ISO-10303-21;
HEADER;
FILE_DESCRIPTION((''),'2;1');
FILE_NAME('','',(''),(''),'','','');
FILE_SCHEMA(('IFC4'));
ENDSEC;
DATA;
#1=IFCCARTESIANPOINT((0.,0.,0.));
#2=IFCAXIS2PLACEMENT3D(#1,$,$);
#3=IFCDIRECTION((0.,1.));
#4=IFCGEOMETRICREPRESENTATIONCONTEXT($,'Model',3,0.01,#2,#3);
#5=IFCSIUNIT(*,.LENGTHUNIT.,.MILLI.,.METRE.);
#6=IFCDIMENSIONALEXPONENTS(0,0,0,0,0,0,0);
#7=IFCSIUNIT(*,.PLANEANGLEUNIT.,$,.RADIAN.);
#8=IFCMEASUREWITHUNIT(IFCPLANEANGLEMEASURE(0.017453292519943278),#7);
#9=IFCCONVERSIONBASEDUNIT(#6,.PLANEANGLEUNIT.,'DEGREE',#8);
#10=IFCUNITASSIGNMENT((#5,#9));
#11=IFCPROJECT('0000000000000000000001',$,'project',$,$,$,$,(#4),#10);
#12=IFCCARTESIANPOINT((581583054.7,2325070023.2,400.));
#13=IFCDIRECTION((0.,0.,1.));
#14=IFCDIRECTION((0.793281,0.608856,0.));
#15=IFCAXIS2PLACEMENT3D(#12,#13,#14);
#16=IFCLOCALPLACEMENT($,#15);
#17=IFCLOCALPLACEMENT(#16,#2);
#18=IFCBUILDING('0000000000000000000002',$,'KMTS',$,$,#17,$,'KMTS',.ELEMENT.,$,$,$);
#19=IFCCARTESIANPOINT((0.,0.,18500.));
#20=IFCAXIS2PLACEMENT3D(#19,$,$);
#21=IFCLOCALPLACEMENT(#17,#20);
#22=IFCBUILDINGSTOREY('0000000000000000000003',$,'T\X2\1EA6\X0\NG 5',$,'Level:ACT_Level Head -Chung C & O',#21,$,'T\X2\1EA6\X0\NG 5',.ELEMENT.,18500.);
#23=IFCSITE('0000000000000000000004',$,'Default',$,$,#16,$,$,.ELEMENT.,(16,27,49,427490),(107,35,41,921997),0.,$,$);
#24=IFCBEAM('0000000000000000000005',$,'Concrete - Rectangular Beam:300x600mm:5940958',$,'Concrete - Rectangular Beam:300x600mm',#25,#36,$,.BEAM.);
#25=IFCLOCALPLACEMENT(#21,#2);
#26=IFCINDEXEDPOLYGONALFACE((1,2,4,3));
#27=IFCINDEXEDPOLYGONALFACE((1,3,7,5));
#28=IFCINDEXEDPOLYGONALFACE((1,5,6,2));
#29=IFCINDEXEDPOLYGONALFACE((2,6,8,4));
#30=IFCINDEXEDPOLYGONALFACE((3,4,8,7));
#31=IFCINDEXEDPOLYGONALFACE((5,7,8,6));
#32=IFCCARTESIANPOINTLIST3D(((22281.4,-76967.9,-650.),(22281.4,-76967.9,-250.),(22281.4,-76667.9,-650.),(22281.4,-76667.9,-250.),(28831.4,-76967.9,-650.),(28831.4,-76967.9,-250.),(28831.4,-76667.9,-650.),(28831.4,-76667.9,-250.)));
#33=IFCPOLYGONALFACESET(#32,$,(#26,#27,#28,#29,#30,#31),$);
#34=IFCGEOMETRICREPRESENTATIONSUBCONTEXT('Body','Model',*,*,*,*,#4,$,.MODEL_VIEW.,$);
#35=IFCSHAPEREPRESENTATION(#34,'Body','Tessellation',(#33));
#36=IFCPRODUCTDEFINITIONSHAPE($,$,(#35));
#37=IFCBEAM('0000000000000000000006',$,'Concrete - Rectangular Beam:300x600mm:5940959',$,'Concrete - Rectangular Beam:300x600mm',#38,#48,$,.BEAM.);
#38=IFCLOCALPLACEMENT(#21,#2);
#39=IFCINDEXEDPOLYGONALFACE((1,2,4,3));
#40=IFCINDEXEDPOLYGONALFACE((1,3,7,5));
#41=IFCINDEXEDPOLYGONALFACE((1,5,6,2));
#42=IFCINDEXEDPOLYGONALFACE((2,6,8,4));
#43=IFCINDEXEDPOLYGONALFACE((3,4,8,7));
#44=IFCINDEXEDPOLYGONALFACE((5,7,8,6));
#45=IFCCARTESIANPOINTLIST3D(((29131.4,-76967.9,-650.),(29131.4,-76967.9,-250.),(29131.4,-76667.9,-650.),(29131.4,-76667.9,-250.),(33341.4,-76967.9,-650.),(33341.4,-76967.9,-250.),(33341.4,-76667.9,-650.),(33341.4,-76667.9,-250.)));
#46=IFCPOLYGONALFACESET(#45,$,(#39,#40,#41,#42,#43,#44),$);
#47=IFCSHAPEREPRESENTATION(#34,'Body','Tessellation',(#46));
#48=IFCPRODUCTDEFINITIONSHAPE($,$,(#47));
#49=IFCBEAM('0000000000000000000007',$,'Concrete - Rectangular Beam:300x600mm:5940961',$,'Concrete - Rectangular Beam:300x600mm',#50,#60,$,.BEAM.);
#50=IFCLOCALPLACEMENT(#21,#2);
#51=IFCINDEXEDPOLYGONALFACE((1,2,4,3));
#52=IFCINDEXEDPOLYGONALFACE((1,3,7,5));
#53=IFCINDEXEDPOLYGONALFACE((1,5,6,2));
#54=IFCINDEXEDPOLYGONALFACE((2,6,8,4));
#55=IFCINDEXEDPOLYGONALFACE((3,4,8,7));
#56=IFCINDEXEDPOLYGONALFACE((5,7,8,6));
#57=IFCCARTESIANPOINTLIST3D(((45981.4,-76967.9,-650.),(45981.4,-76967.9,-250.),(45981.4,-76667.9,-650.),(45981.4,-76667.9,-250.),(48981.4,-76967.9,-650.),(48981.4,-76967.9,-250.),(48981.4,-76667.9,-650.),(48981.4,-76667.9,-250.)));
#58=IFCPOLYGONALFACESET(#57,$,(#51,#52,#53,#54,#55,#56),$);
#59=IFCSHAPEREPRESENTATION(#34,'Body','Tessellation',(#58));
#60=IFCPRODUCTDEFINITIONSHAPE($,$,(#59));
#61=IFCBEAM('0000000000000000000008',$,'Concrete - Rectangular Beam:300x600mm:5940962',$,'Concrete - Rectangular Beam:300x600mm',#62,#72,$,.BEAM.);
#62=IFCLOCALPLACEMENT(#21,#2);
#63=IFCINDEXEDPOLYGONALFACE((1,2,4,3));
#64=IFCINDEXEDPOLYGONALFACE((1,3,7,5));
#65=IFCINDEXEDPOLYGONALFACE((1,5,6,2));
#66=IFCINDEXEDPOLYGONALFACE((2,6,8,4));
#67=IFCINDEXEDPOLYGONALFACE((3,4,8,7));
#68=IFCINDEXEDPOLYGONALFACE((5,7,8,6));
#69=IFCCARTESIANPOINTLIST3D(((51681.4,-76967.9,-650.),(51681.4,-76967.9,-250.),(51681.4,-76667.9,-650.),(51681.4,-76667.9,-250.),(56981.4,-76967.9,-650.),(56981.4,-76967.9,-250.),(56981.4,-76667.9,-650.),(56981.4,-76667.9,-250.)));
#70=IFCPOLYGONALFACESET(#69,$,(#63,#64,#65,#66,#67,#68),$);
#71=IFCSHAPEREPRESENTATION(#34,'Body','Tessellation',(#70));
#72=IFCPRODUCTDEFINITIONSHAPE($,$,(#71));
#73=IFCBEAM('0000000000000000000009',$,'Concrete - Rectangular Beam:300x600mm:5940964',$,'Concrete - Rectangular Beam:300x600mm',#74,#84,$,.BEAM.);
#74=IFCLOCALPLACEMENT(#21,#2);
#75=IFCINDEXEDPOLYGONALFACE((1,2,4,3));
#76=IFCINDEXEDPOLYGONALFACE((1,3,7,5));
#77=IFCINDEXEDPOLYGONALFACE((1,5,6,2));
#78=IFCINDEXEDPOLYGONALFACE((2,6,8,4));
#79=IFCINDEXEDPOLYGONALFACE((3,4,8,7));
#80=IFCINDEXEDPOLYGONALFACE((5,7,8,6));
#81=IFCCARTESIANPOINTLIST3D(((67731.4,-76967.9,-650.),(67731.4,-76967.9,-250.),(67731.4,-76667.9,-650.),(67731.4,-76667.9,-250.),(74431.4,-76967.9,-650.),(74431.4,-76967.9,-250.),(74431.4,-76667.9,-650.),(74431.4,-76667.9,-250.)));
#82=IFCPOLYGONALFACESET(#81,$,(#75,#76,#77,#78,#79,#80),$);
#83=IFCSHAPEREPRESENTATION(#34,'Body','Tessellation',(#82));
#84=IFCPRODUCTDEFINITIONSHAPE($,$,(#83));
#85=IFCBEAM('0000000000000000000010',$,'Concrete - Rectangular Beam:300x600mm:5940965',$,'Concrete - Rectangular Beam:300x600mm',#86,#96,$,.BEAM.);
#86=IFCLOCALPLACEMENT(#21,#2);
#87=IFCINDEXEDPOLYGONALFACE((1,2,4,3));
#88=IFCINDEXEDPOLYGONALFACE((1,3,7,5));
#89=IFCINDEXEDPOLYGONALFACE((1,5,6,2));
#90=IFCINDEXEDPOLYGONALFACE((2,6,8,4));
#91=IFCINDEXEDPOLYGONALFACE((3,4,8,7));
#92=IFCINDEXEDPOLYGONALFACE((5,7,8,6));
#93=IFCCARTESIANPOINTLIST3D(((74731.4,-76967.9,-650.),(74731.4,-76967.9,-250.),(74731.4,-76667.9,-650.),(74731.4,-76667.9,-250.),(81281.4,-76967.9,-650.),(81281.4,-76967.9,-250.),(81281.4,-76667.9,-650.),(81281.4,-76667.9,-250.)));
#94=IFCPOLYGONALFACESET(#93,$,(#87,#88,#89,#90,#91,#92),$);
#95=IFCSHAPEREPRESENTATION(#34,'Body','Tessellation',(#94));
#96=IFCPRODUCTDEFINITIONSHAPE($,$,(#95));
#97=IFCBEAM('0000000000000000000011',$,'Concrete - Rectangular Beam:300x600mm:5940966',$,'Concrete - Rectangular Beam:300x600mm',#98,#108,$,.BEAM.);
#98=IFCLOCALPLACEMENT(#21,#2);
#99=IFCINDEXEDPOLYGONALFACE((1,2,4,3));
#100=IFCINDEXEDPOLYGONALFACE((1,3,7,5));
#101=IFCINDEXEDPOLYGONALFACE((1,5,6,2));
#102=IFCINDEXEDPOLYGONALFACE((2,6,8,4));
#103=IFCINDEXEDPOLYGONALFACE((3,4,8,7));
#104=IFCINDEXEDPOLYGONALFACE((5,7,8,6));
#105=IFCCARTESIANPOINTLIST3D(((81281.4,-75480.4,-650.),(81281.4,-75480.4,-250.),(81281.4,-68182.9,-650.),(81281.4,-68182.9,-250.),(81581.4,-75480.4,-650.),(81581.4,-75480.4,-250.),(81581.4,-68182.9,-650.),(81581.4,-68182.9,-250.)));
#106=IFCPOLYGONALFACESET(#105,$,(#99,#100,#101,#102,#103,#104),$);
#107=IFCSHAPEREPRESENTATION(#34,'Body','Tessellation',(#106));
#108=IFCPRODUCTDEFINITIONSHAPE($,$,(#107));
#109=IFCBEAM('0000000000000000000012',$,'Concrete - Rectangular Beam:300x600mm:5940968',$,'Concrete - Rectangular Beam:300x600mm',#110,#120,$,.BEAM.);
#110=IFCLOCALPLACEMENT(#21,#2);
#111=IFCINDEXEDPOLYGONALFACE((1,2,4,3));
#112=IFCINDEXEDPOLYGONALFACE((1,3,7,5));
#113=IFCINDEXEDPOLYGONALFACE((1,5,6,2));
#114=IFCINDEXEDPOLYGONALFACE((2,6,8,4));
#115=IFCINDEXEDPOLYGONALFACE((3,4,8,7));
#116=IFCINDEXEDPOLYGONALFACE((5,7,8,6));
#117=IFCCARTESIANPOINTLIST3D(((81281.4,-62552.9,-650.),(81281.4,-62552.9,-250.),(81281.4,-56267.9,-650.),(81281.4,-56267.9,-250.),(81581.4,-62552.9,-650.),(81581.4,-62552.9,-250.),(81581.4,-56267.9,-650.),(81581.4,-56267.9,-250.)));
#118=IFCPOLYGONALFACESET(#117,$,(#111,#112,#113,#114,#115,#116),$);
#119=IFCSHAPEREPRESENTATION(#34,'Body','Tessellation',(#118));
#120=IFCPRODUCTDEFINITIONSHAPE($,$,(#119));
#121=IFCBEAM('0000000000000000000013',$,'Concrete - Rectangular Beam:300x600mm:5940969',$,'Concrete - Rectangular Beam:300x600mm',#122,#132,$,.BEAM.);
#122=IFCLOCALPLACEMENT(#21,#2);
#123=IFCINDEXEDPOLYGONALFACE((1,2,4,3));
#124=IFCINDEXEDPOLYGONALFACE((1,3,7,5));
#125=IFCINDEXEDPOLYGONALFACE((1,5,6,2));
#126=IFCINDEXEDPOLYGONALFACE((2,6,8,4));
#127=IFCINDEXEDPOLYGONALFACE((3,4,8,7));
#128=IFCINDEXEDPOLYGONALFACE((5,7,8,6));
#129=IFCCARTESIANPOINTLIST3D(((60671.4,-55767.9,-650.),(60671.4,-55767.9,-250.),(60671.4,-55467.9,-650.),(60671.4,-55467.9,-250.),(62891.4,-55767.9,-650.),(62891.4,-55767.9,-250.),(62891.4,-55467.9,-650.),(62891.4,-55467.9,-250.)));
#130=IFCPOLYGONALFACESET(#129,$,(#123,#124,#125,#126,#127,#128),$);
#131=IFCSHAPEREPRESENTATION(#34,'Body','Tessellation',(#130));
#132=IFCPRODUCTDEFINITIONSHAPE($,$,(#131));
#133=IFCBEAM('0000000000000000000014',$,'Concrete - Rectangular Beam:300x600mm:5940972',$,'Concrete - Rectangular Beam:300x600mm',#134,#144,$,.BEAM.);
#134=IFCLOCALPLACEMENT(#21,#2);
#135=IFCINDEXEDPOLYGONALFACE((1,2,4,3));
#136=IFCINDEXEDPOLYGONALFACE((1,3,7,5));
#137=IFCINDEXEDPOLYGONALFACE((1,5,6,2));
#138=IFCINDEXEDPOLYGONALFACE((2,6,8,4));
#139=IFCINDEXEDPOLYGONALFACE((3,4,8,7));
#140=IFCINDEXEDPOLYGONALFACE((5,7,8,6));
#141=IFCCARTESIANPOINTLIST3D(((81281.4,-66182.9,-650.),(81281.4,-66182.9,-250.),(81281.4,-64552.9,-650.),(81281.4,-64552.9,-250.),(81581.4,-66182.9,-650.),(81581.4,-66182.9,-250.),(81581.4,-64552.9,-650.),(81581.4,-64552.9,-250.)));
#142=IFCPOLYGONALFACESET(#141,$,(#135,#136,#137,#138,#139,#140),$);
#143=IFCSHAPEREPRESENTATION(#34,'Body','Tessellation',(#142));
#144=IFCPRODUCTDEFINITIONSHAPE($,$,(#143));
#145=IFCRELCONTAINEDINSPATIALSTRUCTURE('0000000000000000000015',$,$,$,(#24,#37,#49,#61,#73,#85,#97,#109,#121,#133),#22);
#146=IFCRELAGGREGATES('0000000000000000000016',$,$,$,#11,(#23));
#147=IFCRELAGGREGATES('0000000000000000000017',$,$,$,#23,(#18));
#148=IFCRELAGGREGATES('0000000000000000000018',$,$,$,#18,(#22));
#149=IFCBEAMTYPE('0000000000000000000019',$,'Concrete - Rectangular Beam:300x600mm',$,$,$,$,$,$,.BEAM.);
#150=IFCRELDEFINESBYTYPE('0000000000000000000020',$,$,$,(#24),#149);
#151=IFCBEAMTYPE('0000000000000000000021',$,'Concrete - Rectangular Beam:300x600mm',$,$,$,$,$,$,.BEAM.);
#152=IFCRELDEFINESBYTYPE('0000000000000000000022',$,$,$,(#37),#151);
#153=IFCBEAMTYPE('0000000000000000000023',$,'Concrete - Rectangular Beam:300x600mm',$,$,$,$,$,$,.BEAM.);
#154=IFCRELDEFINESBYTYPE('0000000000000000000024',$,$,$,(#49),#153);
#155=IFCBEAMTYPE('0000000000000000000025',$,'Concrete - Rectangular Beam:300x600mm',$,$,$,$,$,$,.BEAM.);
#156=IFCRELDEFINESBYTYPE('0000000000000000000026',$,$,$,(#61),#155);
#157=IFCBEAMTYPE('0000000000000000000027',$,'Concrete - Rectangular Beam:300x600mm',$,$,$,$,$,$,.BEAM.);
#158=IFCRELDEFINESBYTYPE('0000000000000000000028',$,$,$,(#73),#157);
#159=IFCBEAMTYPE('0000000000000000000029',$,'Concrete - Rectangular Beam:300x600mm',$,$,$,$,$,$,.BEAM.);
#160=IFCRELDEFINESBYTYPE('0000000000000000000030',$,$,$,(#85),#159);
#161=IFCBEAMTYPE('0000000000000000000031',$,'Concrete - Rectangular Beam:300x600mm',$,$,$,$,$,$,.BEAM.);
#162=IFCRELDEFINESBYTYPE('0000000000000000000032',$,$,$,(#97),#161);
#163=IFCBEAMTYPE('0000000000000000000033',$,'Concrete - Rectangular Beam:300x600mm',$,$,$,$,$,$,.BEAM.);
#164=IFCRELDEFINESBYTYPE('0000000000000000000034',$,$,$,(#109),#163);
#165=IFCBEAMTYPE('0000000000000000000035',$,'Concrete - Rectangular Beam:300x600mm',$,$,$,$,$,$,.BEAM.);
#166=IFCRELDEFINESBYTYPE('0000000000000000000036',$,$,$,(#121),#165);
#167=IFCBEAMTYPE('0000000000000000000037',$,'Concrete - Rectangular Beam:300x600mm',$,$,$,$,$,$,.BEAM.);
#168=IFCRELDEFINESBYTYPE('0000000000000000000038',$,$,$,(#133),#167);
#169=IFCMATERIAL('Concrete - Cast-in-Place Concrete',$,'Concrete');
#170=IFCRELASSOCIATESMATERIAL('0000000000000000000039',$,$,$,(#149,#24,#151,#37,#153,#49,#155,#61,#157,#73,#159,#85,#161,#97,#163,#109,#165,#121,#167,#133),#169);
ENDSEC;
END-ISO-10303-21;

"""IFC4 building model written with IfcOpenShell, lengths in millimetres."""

from ifc_helpers import new_model, entity, si_unit, converted_unit, direction, frame, origin, place, context, subcontext, project, spatial, indexed_curve, outline, extrude, source, transform, mapped, material, type_object, type_shapes, element, save


model = new_model("IFC4")

# Units and contexts
model_context = context("Model", 3, precision=0.01, world=origin(), true_north=direction((0.0, 1.0)))
body_context = subcontext(model_context, "Body", "Model", "MODEL_VIEW")
ifc_project = project(units=[si_unit("LENGTHUNIT", "METRE", prefix="MILLI"), converted_unit("PLANEANGLEUNIT", "DEGREE", entity("IfcPlaneAngleMeasure", 0.017453292519943278), si_unit("PLANEANGLEUNIT", "RADIAN"), dimensions=[0, 0, 0, 0, 0, 0, 0])], contexts=[model_context])

# Site, building, storey
site_placement = place(None, frame((581583054.7, 2325070023.2, 400.0), z_axis=(0.0, 0.0, 1.0), x_axis=(0.793281, 0.608856, 0.0)))
site = spatial("IfcSite", under=ifc_project, at=site_placement, Name="Default", CompositionType="ELEMENT", RefLatitude=(16, 27, 49, 427490), RefLongitude=(107, 35, 41, 921997), RefElevation=0.0)
building_placement = place(site_placement, origin())
building = spatial("IfcBuilding", under=site, at=building_placement, Name="KMTS", LongName="KMTS", CompositionType="ELEMENT")
storey_placement = place(building_placement, frame((0.0, 0.0, 18500.0)))
storey = spatial("IfcBuildingStorey", under=building, at=storey_placement, Name="TẦNG 5", ObjectType="Level:ACT_Level Head -Chung C & O", LongName="TẦNG 5", CompositionType="ELEMENT", Elevation=18500.0)

# Beams
ifc_material_1 = material(Name="Concrete - Cast-in-Place Concrete", Category="Concrete")
beam_type_1 = type_object("IfcBeamType", Name="Concrete - Rectangular Beam:300x600mm", PredefinedType="BEAM", material=ifc_material_1)
shared_shape_1 = source(origin(), body_context, "Body", "SweptSolid", [
    extrude(outline(indexed_curve([(-200.0, -150.0), (200.0, -150.0), (200.0, 150.0), (-200.0, 150.0), (-200.0, -150.0)], self_intersect=False)), frame((22281.4, -76817.9, 18050.0), z_axis=(1.0, 0.0, 0.0), x_axis=(0.0, 0.0, -1.0)), (0.0, 0.0, 1.0), 6550.0),
])
type_shapes(beam_type_1, [shared_shape_1])
beam_1_placement = place(storey_placement, frame((0.0, 0.0, -18500.0)))
element("IfcBeam", 1, at=beam_1_placement, inside=storey, type_object=beam_type_1, material=ifc_material_1, Name="Concrete - Rectangular Beam:300x600mm:5940958", ObjectType="Concrete - Rectangular Beam:300x600mm", PredefinedType="BEAM", context=body_context, shape_type="MappedRepresentation", body=[
    mapped(shared_shape_1, transform((0.0, 0.0, 0.0), scale=1.0)),
])
beam_type_2 = type_object("IfcBeamType", Name="Concrete - Rectangular Beam:300x600mm", PredefinedType="BEAM", material=ifc_material_1)
shared_shape_2 = source(origin(), body_context, "Body", "SweptSolid", [
    extrude(outline(indexed_curve([(-200.0, -150.0), (200.0, -150.0), (200.0, 150.0), (-200.0, 150.0), (-200.0, -150.0)], self_intersect=False)), frame((29131.4, -76817.9, 18050.0), z_axis=(1.0, 0.0, 0.0), x_axis=(0.0, 0.0, -1.0)), (0.0, 0.0, 1.0), 4210.0),
])
type_shapes(beam_type_2, [shared_shape_2])
beam_2_placement = place(storey_placement, frame((0.0, 0.0, -18500.0)))
element("IfcBeam", 2, at=beam_2_placement, inside=storey, type_object=beam_type_2, material=ifc_material_1, Name="Concrete - Rectangular Beam:300x600mm:5940959", ObjectType="Concrete - Rectangular Beam:300x600mm", PredefinedType="BEAM", context=body_context, shape_type="MappedRepresentation", body=[
    mapped(shared_shape_2, transform((0.0, 0.0, 0.0), scale=1.0)),
])
beam_type_3 = type_object("IfcBeamType", Name="Concrete - Rectangular Beam:300x600mm", PredefinedType="BEAM", material=ifc_material_1)
shared_shape_3 = source(origin(), body_context, "Body", "SweptSolid", [
    extrude(outline(indexed_curve([(-200.0, -150.0), (200.0, -150.0), (200.0, 150.0), (-200.0, 150.0), (-200.0, -150.0)], self_intersect=False)), frame((45981.4, -76817.9, 18050.0), z_axis=(1.0, 0.0, 0.0), x_axis=(0.0, 0.0, -1.0)), (0.0, 0.0, 1.0), 3000.0),
])
type_shapes(beam_type_3, [shared_shape_3])
beam_3_placement = place(storey_placement, frame((0.0, 0.0, -18500.0)))
element("IfcBeam", 3, at=beam_3_placement, inside=storey, type_object=beam_type_3, material=ifc_material_1, Name="Concrete - Rectangular Beam:300x600mm:5940961", ObjectType="Concrete - Rectangular Beam:300x600mm", PredefinedType="BEAM", context=body_context, shape_type="MappedRepresentation", body=[
    mapped(shared_shape_3, transform((0.0, 0.0, 0.0), scale=1.0)),
])
beam_type_4 = type_object("IfcBeamType", Name="Concrete - Rectangular Beam:300x600mm", PredefinedType="BEAM", material=ifc_material_1)
shared_shape_4 = source(origin(), body_context, "Body", "SweptSolid", [
    extrude(outline(indexed_curve([(-200.0, -150.0), (200.0, -150.0), (200.0, 150.0), (-200.0, 150.0), (-200.0, -150.0)], self_intersect=False)), frame((51681.4, -76817.9, 18050.0), z_axis=(1.0, 0.0, 0.0), x_axis=(0.0, 0.0, -1.0)), (0.0, 0.0, 1.0), 5300.0),
])
type_shapes(beam_type_4, [shared_shape_4])
beam_4_placement = place(storey_placement, frame((0.0, 0.0, -18500.0)))
element("IfcBeam", 4, at=beam_4_placement, inside=storey, type_object=beam_type_4, material=ifc_material_1, Name="Concrete - Rectangular Beam:300x600mm:5940962", ObjectType="Concrete - Rectangular Beam:300x600mm", PredefinedType="BEAM", context=body_context, shape_type="MappedRepresentation", body=[
    mapped(shared_shape_4, transform((0.0, 0.0, 0.0), scale=1.0)),
])
beam_type_5 = type_object("IfcBeamType", Name="Concrete - Rectangular Beam:300x600mm", PredefinedType="BEAM", material=ifc_material_1)
shared_shape_5 = source(origin(), body_context, "Body", "SweptSolid", [
    extrude(outline(indexed_curve([(-200.0, -150.0), (200.0, -150.0), (200.0, 150.0), (-200.0, 150.0), (-200.0, -150.0)], self_intersect=False)), frame((67731.4, -76817.9, 18050.0), z_axis=(1.0, 0.0, 0.0), x_axis=(0.0, 0.0, -1.0)), (0.0, 0.0, 1.0), 6700.0),
])
type_shapes(beam_type_5, [shared_shape_5])
beam_5_placement = place(storey_placement, frame((0.0, 0.0, -18500.0)))
element("IfcBeam", 5, at=beam_5_placement, inside=storey, type_object=beam_type_5, material=ifc_material_1, Name="Concrete - Rectangular Beam:300x600mm:5940964", ObjectType="Concrete - Rectangular Beam:300x600mm", PredefinedType="BEAM", context=body_context, shape_type="MappedRepresentation", body=[
    mapped(shared_shape_5, transform((0.0, 0.0, 0.0), scale=1.0)),
])
beam_type_6 = type_object("IfcBeamType", Name="Concrete - Rectangular Beam:300x600mm", PredefinedType="BEAM", material=ifc_material_1)
shared_shape_6 = source(origin(), body_context, "Body", "SweptSolid", [
    extrude(outline(indexed_curve([(-200.0, -150.0), (200.0, -150.0), (200.0, 150.0), (-200.0, 150.0), (-200.0, -150.0)], self_intersect=False)), frame((74731.4, -76817.9, 18050.0), z_axis=(1.0, 0.0, 0.0), x_axis=(0.0, 0.0, -1.0)), (0.0, 0.0, 1.0), 6550.0),
])
type_shapes(beam_type_6, [shared_shape_6])
beam_6_placement = place(storey_placement, frame((0.0, 0.0, -18500.0)))
element("IfcBeam", 6, at=beam_6_placement, inside=storey, type_object=beam_type_6, material=ifc_material_1, Name="Concrete - Rectangular Beam:300x600mm:5940965", ObjectType="Concrete - Rectangular Beam:300x600mm", PredefinedType="BEAM", context=body_context, shape_type="MappedRepresentation", body=[
    mapped(shared_shape_6, transform((0.0, 0.0, 0.0), scale=1.0)),
])
beam_type_7 = type_object("IfcBeamType", Name="Concrete - Rectangular Beam:300x600mm", PredefinedType="BEAM", material=ifc_material_1)
shared_shape_7 = source(origin(), body_context, "Body", "SweptSolid", [
    extrude(outline(indexed_curve([(-150.0, -200.0), (150.0, -200.0), (150.0, 200.0), (-150.0, 200.0), (-150.0, -200.0)], self_intersect=False)), frame((81431.4, -68182.9, 18050.0), z_axis=(0.0, -1.0, 0.0), x_axis=(-1.0, 0.0, 0.0)), (0.0, 0.0, 1.0), 7297.5),
])
type_shapes(beam_type_7, [shared_shape_7])
beam_7_placement = place(storey_placement, frame((0.0, 0.0, -18500.0)))
element("IfcBeam", 7, at=beam_7_placement, inside=storey, type_object=beam_type_7, material=ifc_material_1, Name="Concrete - Rectangular Beam:300x600mm:5940966", ObjectType="Concrete - Rectangular Beam:300x600mm", PredefinedType="BEAM", context=body_context, shape_type="MappedRepresentation", body=[
    mapped(shared_shape_7, transform((0.0, 0.0, 0.0), scale=1.0)),
])
beam_type_8 = type_object("IfcBeamType", Name="Concrete - Rectangular Beam:300x600mm", PredefinedType="BEAM", material=ifc_material_1)
shared_shape_8 = source(origin(), body_context, "Body", "SweptSolid", [
    extrude(outline(indexed_curve([(-150.0, -200.0), (150.0, -200.0), (150.0, 200.0), (-150.0, 200.0), (-150.0, -200.0)], self_intersect=False)), frame((81431.4, -56267.9, 18050.0), z_axis=(0.0, -1.0, 0.0), x_axis=(-1.0, 0.0, 0.0)), (0.0, 0.0, 1.0), 6285.0),
])
type_shapes(beam_type_8, [shared_shape_8])
beam_8_placement = place(storey_placement, frame((0.0, 0.0, -18500.0)))
element("IfcBeam", 8, at=beam_8_placement, inside=storey, type_object=beam_type_8, material=ifc_material_1, Name="Concrete - Rectangular Beam:300x600mm:5940968", ObjectType="Concrete - Rectangular Beam:300x600mm", PredefinedType="BEAM", context=body_context, shape_type="MappedRepresentation", body=[
    mapped(shared_shape_8, transform((0.0, 0.0, 0.0), scale=1.0)),
])
beam_type_9 = type_object("IfcBeamType", Name="Concrete - Rectangular Beam:300x600mm", PredefinedType="BEAM", material=ifc_material_1)
shared_shape_9 = source(origin(), body_context, "Body", "SweptSolid", [
    extrude(outline(indexed_curve([(-200.0, -150.0), (200.0, -150.0), (200.0, 150.0), (-200.0, 150.0), (-200.0, -150.0)], self_intersect=False)), frame((62891.4, -55617.9, 18050.0), z_axis=(-1.0, 0.0, 0.0), x_axis=(0.0, 0.0, -1.0)), (0.0, 0.0, 1.0), 2220.0),
])
type_shapes(beam_type_9, [shared_shape_9])
beam_9_placement = place(storey_placement, frame((0.0, 0.0, -18500.0)))
element("IfcBeam", 9, at=beam_9_placement, inside=storey, type_object=beam_type_9, material=ifc_material_1, Name="Concrete - Rectangular Beam:300x600mm:5940969", ObjectType="Concrete - Rectangular Beam:300x600mm", PredefinedType="BEAM", context=body_context, shape_type="MappedRepresentation", body=[
    mapped(shared_shape_9, transform((0.0, 0.0, 0.0), scale=1.0)),
])
beam_type_10 = type_object("IfcBeamType", Name="Concrete - Rectangular Beam:300x600mm", PredefinedType="BEAM", material=ifc_material_1)
shared_shape_10 = source(origin(), body_context, "Body", "SweptSolid", [
    extrude(outline(indexed_curve([(-150.0, -200.0), (150.0, -200.0), (150.0, 200.0), (-150.0, 200.0), (-150.0, -200.0)], self_intersect=False)), frame((81431.4, -66182.9, 18050.0), z_axis=(0.0, 1.0, 0.0), x_axis=(-1.0, 0.0, 0.0)), (0.0, 0.0, 1.0), 1630.0),
])
type_shapes(beam_type_10, [shared_shape_10])
beam_10_placement = place(storey_placement, frame((0.0, 0.0, -18500.0)))
element("IfcBeam", 10, at=beam_10_placement, inside=storey, type_object=beam_type_10, material=ifc_material_1, Name="Concrete - Rectangular Beam:300x600mm:5940972", ObjectType="Concrete - Rectangular Beam:300x600mm", PredefinedType="BEAM", context=body_context, shape_type="MappedRepresentation", body=[
    mapped(shared_shape_10, transform((0.0, 0.0, 0.0), scale=1.0)),
])

save(model, "model.ifc")
